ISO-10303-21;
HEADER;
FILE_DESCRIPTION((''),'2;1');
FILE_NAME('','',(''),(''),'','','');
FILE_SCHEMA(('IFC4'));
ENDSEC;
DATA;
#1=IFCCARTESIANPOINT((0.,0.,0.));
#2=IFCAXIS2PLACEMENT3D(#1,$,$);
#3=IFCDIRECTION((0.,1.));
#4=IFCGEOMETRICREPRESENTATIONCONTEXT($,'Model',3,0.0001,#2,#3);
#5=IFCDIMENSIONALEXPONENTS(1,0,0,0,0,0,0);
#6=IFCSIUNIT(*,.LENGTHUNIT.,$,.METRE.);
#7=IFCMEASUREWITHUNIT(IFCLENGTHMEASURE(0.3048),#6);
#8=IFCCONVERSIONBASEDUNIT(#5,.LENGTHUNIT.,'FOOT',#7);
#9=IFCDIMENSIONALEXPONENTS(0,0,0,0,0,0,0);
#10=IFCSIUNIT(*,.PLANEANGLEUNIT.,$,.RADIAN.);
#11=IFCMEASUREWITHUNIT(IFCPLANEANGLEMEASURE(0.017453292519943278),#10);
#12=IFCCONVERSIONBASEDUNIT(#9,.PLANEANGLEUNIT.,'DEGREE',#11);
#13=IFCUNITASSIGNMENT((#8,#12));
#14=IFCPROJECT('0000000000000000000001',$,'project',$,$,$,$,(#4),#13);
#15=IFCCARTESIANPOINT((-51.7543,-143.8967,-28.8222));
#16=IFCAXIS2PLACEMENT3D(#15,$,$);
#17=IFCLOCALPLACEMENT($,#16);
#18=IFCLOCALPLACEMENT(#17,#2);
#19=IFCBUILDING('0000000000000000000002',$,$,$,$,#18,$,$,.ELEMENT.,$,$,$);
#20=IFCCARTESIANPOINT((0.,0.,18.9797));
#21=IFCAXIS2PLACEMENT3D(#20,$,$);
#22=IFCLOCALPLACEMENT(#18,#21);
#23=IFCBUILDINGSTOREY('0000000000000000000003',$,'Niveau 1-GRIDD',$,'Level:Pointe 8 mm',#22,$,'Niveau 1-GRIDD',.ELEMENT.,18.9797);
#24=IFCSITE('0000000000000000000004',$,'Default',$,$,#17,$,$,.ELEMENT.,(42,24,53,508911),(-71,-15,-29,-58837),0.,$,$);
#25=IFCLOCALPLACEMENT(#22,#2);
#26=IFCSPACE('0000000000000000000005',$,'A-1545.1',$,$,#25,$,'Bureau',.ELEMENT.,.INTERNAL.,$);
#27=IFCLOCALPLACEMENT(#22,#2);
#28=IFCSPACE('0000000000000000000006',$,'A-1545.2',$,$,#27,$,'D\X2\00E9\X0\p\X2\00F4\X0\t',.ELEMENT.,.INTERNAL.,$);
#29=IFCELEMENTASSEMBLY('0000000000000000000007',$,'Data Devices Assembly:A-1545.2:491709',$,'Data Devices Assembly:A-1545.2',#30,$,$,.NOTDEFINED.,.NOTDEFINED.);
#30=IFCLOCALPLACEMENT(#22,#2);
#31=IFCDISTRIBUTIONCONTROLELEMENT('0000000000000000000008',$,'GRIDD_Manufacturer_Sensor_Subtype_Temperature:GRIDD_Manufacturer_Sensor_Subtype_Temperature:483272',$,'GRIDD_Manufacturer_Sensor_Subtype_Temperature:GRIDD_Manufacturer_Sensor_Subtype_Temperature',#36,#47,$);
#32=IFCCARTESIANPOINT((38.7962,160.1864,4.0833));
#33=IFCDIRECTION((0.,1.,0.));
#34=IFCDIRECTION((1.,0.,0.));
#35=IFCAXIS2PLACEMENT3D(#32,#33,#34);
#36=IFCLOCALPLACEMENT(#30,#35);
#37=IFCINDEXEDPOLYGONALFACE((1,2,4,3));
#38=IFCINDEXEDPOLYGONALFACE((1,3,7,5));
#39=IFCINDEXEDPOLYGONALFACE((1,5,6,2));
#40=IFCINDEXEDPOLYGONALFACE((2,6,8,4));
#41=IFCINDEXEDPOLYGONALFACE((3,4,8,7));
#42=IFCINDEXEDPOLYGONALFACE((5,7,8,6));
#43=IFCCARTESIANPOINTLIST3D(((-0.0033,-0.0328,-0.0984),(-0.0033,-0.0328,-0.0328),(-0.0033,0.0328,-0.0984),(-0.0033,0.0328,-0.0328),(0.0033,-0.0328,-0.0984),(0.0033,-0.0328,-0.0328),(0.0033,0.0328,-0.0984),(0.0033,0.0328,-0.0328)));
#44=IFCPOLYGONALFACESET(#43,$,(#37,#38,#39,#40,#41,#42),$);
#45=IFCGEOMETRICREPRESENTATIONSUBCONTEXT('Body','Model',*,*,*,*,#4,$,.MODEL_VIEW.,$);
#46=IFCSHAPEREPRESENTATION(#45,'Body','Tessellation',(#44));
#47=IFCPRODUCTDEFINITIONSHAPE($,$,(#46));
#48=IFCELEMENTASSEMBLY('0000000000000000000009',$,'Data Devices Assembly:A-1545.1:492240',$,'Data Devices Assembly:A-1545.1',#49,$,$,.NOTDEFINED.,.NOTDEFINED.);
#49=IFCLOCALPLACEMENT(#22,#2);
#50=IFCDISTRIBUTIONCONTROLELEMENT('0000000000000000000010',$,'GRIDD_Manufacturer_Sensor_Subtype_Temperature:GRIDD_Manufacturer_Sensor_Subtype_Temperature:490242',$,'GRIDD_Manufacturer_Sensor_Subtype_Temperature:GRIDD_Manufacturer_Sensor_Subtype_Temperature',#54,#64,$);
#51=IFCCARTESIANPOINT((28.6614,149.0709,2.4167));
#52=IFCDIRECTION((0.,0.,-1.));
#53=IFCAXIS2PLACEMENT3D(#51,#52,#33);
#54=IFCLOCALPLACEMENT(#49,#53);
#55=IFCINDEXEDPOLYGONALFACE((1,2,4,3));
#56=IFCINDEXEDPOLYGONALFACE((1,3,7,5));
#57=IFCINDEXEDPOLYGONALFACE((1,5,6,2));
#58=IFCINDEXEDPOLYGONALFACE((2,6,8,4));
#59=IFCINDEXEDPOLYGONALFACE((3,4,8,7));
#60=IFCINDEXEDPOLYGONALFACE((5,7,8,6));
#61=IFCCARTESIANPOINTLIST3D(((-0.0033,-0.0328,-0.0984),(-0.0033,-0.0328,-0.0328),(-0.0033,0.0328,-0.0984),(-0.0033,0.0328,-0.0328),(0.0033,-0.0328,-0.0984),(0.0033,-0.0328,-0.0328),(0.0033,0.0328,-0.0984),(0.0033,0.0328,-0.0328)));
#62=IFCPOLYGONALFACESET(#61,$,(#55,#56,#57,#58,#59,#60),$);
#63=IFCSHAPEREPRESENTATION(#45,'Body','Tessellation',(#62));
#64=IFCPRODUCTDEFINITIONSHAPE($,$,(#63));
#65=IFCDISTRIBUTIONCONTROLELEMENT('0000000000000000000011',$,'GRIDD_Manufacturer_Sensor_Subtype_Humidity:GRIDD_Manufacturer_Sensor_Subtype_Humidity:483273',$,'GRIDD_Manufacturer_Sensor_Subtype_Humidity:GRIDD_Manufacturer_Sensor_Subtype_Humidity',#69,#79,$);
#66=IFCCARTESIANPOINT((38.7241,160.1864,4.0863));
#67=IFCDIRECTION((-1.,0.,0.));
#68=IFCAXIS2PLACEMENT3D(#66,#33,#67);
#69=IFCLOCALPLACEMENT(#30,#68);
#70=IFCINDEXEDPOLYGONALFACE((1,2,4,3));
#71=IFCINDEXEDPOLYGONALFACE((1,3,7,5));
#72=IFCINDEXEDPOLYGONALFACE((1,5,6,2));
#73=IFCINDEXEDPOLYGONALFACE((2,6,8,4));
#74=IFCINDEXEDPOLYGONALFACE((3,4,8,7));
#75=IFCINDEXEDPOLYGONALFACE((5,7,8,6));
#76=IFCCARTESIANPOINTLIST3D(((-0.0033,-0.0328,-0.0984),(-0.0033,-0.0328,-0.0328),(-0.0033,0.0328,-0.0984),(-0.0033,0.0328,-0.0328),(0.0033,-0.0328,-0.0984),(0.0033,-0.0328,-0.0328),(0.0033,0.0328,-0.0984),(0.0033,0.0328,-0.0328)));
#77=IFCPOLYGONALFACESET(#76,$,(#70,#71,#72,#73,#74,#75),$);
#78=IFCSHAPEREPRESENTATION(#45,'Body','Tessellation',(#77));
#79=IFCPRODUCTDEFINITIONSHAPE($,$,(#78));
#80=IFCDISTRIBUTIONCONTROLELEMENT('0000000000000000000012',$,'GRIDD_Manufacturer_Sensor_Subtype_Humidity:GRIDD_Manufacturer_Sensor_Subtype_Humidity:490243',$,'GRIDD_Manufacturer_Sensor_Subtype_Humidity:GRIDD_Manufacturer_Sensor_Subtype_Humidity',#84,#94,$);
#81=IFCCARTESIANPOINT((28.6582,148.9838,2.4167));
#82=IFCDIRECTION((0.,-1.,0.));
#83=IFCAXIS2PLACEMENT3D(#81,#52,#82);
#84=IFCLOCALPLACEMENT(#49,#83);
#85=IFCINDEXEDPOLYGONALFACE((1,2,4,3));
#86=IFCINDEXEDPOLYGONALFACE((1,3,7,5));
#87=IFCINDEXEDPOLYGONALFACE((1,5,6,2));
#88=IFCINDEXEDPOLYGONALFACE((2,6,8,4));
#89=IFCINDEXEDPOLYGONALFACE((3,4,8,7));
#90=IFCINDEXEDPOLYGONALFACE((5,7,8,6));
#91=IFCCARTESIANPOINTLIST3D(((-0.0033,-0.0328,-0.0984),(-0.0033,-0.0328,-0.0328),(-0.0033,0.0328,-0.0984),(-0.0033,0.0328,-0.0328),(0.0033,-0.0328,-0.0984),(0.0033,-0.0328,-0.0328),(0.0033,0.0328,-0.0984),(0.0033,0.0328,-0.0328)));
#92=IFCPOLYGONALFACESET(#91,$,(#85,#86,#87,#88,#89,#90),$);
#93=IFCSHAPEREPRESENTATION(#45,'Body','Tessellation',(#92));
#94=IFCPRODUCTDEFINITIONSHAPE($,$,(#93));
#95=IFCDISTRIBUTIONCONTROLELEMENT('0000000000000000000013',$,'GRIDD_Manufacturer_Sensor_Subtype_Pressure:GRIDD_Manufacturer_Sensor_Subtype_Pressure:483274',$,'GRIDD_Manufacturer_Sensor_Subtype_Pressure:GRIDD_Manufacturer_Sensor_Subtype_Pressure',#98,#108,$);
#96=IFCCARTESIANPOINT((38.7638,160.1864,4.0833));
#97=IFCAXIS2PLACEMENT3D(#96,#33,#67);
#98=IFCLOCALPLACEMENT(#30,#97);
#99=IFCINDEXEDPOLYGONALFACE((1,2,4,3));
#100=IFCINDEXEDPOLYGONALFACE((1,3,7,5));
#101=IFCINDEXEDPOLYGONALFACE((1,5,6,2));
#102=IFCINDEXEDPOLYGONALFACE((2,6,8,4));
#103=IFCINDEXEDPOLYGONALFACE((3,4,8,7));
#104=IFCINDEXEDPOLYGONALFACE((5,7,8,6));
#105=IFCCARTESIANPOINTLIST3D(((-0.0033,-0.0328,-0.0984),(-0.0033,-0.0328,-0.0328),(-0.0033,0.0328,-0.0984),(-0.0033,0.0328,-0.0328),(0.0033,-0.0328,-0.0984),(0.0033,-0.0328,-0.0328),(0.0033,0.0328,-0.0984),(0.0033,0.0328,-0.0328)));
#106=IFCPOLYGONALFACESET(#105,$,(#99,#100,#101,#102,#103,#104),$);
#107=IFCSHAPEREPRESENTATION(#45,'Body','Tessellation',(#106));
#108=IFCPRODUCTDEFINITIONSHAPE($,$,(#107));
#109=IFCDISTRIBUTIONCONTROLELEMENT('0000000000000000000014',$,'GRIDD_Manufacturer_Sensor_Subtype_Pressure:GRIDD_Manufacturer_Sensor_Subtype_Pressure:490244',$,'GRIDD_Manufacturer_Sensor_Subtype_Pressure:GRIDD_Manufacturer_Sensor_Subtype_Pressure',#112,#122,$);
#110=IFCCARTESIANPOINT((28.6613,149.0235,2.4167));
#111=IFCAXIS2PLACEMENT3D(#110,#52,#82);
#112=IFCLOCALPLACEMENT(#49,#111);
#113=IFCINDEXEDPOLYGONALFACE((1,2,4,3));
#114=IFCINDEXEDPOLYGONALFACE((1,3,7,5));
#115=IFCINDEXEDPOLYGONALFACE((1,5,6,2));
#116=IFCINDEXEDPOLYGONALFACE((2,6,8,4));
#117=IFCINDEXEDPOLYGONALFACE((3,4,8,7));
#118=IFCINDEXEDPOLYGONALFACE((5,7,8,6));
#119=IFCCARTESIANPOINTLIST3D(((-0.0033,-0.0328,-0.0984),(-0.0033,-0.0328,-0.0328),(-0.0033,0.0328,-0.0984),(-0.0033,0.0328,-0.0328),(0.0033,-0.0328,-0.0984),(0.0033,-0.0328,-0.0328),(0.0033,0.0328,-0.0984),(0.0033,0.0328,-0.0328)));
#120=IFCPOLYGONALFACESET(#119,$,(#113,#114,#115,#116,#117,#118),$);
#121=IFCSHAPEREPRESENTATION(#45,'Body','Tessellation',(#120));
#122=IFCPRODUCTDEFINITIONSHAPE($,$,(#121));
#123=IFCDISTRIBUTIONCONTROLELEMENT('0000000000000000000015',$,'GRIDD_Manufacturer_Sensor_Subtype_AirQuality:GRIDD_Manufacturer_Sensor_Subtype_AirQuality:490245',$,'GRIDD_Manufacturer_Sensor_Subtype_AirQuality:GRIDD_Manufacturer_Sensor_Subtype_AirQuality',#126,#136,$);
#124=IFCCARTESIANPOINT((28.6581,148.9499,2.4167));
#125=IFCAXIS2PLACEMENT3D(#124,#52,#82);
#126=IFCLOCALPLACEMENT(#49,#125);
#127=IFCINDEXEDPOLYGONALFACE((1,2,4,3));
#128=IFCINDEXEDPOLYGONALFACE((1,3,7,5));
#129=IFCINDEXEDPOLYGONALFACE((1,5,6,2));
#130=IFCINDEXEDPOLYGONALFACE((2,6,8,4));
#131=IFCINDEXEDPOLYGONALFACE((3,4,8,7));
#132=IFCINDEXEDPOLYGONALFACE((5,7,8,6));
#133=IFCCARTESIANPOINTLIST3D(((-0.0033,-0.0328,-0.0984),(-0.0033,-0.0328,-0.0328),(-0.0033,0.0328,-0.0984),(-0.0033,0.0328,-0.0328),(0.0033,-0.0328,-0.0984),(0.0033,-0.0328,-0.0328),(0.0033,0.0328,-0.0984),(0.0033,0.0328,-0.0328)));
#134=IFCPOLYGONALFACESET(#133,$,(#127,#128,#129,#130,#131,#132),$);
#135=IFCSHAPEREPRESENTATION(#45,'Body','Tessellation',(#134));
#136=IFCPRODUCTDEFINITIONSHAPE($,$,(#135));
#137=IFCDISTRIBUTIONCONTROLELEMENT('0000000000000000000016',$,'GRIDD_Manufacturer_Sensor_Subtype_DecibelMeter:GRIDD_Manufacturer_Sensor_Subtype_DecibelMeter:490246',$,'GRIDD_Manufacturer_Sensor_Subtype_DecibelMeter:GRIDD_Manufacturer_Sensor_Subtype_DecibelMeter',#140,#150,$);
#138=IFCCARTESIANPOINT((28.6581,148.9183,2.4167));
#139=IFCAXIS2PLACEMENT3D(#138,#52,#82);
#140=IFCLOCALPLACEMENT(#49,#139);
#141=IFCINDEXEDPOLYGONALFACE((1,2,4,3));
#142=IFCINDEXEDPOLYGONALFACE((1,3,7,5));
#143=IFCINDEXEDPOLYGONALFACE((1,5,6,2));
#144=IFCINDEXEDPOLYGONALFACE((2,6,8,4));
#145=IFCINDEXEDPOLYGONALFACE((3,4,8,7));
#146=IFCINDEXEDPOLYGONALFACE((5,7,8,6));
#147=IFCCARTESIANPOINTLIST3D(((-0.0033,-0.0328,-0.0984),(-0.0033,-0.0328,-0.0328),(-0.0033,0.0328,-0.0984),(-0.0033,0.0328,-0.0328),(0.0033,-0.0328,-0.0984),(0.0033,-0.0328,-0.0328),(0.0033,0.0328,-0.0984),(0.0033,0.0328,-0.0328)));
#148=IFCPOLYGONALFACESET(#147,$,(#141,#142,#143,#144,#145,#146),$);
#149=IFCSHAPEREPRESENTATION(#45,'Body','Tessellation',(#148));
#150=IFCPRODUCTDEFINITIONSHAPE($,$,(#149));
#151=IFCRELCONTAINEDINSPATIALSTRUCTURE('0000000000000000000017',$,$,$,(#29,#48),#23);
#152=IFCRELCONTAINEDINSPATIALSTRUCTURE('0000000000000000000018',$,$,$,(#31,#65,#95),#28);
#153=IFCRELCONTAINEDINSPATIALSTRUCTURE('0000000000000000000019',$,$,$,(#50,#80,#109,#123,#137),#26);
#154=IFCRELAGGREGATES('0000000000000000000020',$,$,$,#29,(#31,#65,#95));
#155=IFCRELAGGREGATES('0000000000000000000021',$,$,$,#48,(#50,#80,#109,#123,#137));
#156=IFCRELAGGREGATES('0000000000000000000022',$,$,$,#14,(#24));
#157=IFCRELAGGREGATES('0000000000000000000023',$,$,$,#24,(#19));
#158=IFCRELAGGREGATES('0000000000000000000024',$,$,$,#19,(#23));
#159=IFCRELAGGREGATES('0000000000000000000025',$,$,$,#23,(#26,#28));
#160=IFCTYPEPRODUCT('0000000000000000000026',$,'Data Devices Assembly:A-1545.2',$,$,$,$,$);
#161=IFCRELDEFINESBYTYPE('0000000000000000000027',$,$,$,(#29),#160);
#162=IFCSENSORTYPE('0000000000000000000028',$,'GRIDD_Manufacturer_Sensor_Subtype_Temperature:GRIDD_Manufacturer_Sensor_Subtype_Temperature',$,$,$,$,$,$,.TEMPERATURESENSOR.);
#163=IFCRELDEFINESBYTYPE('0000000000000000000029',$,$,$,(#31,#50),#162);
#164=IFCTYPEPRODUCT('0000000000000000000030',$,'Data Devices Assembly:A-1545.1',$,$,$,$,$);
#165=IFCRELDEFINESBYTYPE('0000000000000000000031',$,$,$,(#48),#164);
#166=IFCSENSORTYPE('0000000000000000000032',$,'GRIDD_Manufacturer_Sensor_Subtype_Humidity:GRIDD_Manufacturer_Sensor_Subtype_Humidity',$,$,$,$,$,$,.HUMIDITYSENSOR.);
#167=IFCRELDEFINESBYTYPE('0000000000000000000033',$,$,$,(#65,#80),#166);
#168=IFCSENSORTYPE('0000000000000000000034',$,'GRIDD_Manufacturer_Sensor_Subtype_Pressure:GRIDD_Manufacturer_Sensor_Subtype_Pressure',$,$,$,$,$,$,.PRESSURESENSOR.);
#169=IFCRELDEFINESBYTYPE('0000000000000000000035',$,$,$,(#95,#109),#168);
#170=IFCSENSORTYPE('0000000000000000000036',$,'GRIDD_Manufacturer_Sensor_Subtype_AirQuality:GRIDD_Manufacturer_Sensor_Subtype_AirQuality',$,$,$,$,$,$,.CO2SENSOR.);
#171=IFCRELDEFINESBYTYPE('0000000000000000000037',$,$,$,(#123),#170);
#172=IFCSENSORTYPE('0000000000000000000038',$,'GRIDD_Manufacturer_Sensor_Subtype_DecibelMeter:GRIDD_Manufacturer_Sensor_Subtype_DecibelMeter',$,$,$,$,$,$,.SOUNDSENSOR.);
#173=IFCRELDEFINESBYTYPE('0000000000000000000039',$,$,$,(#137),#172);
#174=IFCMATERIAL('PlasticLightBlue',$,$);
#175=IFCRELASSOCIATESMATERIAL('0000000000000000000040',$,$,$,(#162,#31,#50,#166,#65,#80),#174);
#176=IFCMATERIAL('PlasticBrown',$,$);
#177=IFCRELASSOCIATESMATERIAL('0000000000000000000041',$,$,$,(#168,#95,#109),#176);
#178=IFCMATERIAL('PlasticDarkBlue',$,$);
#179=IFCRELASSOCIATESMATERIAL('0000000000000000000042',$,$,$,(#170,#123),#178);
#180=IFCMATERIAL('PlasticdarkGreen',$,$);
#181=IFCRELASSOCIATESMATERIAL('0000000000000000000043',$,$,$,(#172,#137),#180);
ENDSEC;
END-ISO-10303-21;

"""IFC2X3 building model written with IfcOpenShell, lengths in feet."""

from ifc_helpers import new_model, entity, si_unit, converted_unit, direction, frame, origin, origin_2d_with_axis, place, context, subcontext, project, spatial, rectangle, extrude, source, transform, mapped, material, type_object, type_shapes, element, aggregate, save


model = new_model("IFC2X3")

# Units and contexts
model_context = context("Model", 3, precision=0.0001, world=origin(), true_north=direction((0.0, 1.0)))
body_context = subcontext(model_context, "Body", "Model", "MODEL_VIEW")
ifc_project = project(units=[converted_unit("LENGTHUNIT", "FOOT", entity("IfcLengthMeasure", 0.3048), si_unit("LENGTHUNIT", "METRE"), dimensions=[1, 0, 0, 0, 0, 0, 0]), converted_unit("PLANEANGLEUNIT", "DEGREE", entity("IfcPlaneAngleMeasure", 0.017453292519943278), si_unit("PLANEANGLEUNIT", "RADIAN"), dimensions=[0, 0, 0, 0, 0, 0, 0])], contexts=[model_context])

# Site, building, storey
site_placement = place(None, frame((-51.7543, -143.8967, -28.8222)))
site = spatial("IfcSite", under=ifc_project, at=site_placement, Name="Default", CompositionType="ELEMENT", RefLatitude=(42, 24, 53, 508911), RefLongitude=(-71, -15, -29, -58837), RefElevation=0.0)
building_placement = place(site_placement, origin())
building = spatial("IfcBuilding", under=site, at=building_placement, CompositionType="ELEMENT")
storey_placement = place(building_placement, frame((0.0, 0.0, 18.9797)))
storey = spatial("IfcBuildingStorey", under=building, at=storey_placement, Name="Niveau 1-GRIDD", ObjectType="Level:Pointe 8 mm", LongName="Niveau 1-GRIDD", CompositionType="ELEMENT", Elevation=18.9797)

# Shared definitions
space_1_placement = place(storey_placement, origin())
space_1 = spatial("IfcSpace", under=storey, at=space_1_placement, Name="A-1545.1", LongName="Bureau", CompositionType="ELEMENT", InteriorOrExteriorSpace="INTERNAL")

# Shared definitions
space_2_placement = place(storey_placement, origin())
space_2 = spatial("IfcSpace", under=storey, at=space_2_placement, Name="A-1545.2", LongName="Dépôt", CompositionType="ELEMENT", InteriorOrExteriorSpace="INTERNAL")

# Element assemblies, distribution control elements
type_product_1 = type_object("IfcTypeProduct", Name="Data Devices Assembly:A-1545.2")
assembly_1_placement = place(storey_placement, origin())
assembly_1 = element("IfcElementAssembly", 1, at=assembly_1_placement, inside=storey, type_object=type_product_1, Name="Data Devices Assembly:A-1545.2:491709", ObjectType="Data Devices Assembly:A-1545.2", AssemblyPlace="NOTDEFINED", PredefinedType="NOTDEFINED")
ifc_material_1 = material(Name="PlasticLightBlue")
sensor_type_1 = type_object("IfcSensorType", Name="GRIDD_Manufacturer_Sensor_Subtype_Temperature:GRIDD_Manufacturer_Sensor_Subtype_Temperature", PredefinedType="TEMPERATURESENSOR", material=ifc_material_1)
shared_shape_1 = source(origin(), body_context, "Body", "SweptSolid", [
    extrude(rectangle(XDim=0.0066, YDim=0.0656, at=origin_2d_with_axis()), frame((0.0, 0.0, -0.0984), z_axis=(0.0, 0.0, 1.0), x_axis=(-1.0, 0.0, 0.0)), (0.0, 0.0, 1.0), 0.0656),
])
type_shapes(sensor_type_1, [shared_shape_1])
distribution_control_element_1_placement = place(assembly_1_placement, frame((38.7962, 160.1864, 4.0833), z_axis=(0.0, 1.0, 0.0), x_axis=(1.0, 0.0, 0.0)))
distribution_control_element_1 = element("IfcDistributionControlElement", 2, at=distribution_control_element_1_placement, inside=space_2, type_object=sensor_type_1, material=ifc_material_1, Name="GRIDD_Manufacturer_Sensor_Subtype_Temperature:GRIDD_Manufacturer_Sensor_Subtype_Temperature:483272", ObjectType="GRIDD_Manufacturer_Sensor_Subtype_Temperature:GRIDD_Manufacturer_Sensor_Subtype_Temperature", context=body_context, shape_type="MappedRepresentation", body=[
    mapped(shared_shape_1, transform((0.0, 0.0, 0.0), scale=1.0)),
])
type_product_2 = type_object("IfcTypeProduct", Name="Data Devices Assembly:A-1545.1")
assembly_2_placement = place(storey_placement, origin())
assembly_2 = element("IfcElementAssembly", 3, at=assembly_2_placement, inside=storey, type_object=type_product_2, Name="Data Devices Assembly:A-1545.1:492240", ObjectType="Data Devices Assembly:A-1545.1", AssemblyPlace="NOTDEFINED", PredefinedType="NOTDEFINED")
distribution_control_element_2_placement = place(assembly_2_placement, frame((28.6614, 149.0709, 2.4167), z_axis=(0.0, 0.0, -1.0), x_axis=(0.0, 1.0, 0.0)))
distribution_control_element_2 = element("IfcDistributionControlElement", 4, at=distribution_control_element_2_placement, inside=space_1, type_object=sensor_type_1, material=ifc_material_1, Name="GRIDD_Manufacturer_Sensor_Subtype_Temperature:GRIDD_Manufacturer_Sensor_Subtype_Temperature:490242", ObjectType="GRIDD_Manufacturer_Sensor_Subtype_Temperature:GRIDD_Manufacturer_Sensor_Subtype_Temperature", context=body_context, shape_type="MappedRepresentation", body=[
    mapped(shared_shape_1, transform((0.0, 0.0, 0.0), scale=1.0)),
])

# Distribution control elements
sensor_type_2 = type_object("IfcSensorType", Name="GRIDD_Manufacturer_Sensor_Subtype_Humidity:GRIDD_Manufacturer_Sensor_Subtype_Humidity", PredefinedType="HUMIDITYSENSOR", material=ifc_material_1)
shared_shape_2 = source(origin(), body_context, "Body", "SweptSolid", [
    extrude(rectangle(XDim=0.0066, YDim=0.0656, at=origin_2d_with_axis()), frame((0.0, 0.0, -0.0984), z_axis=(0.0, 0.0, 1.0), x_axis=(-1.0, 0.0, 0.0)), (0.0, 0.0, 1.0), 0.0656),
])
type_shapes(sensor_type_2, [shared_shape_2])
distribution_control_element_3_placement = place(assembly_1_placement, frame((38.7241, 160.1864, 4.0863), z_axis=(0.0, 1.0, 0.0), x_axis=(-1.0, 0.0, 0.0)))
distribution_control_element_3 = element("IfcDistributionControlElement", 5, at=distribution_control_element_3_placement, inside=space_2, type_object=sensor_type_2, material=ifc_material_1, Name="GRIDD_Manufacturer_Sensor_Subtype_Humidity:GRIDD_Manufacturer_Sensor_Subtype_Humidity:483273", ObjectType="GRIDD_Manufacturer_Sensor_Subtype_Humidity:GRIDD_Manufacturer_Sensor_Subtype_Humidity", context=body_context, shape_type="MappedRepresentation", body=[
    mapped(shared_shape_2, transform((0.0, 0.0, 0.0), scale=1.0)),
])
distribution_control_element_4_placement = place(assembly_2_placement, frame((28.6582, 148.9838, 2.4167), z_axis=(0.0, 0.0, -1.0), x_axis=(0.0, -1.0, 0.0)))
distribution_control_element_4 = element("IfcDistributionControlElement", 6, at=distribution_control_element_4_placement, inside=space_1, type_object=sensor_type_2, material=ifc_material_1, Name="GRIDD_Manufacturer_Sensor_Subtype_Humidity:GRIDD_Manufacturer_Sensor_Subtype_Humidity:490243", ObjectType="GRIDD_Manufacturer_Sensor_Subtype_Humidity:GRIDD_Manufacturer_Sensor_Subtype_Humidity", context=body_context, shape_type="MappedRepresentation", body=[
    mapped(shared_shape_2, transform((0.0, 0.0, 0.0), scale=1.0)),
])
ifc_material_2 = material(Name="PlasticBrown")
sensor_type_3 = type_object("IfcSensorType", Name="GRIDD_Manufacturer_Sensor_Subtype_Pressure:GRIDD_Manufacturer_Sensor_Subtype_Pressure", PredefinedType="PRESSURESENSOR", material=ifc_material_2)
shared_shape_3 = source(origin(), body_context, "Body", "SweptSolid", [
    extrude(rectangle(XDim=0.0066, YDim=0.0656, at=origin_2d_with_axis()), frame((0.0, 0.0, -0.0984), z_axis=(0.0, 0.0, 1.0), x_axis=(-1.0, 0.0, 0.0)), (0.0, 0.0, 1.0), 0.0656),
])
type_shapes(sensor_type_3, [shared_shape_3])
distribution_control_element_5_placement = place(assembly_1_placement, frame((38.7638, 160.1864, 4.0833), z_axis=(0.0, 1.0, 0.0), x_axis=(-1.0, 0.0, 0.0)))
distribution_control_element_5 = element("IfcDistributionControlElement", 7, at=distribution_control_element_5_placement, inside=space_2, type_object=sensor_type_3, material=ifc_material_2, Name="GRIDD_Manufacturer_Sensor_Subtype_Pressure:GRIDD_Manufacturer_Sensor_Subtype_Pressure:483274", ObjectType="GRIDD_Manufacturer_Sensor_Subtype_Pressure:GRIDD_Manufacturer_Sensor_Subtype_Pressure", context=body_context, shape_type="MappedRepresentation", body=[
    mapped(shared_shape_3, transform((0.0, 0.0, 0.0), scale=1.0)),
])
aggregate(assembly_1, [distribution_control_element_1, distribution_control_element_3, distribution_control_element_5])
distribution_control_element_6_placement = place(assembly_2_placement, frame((28.6613, 149.0235, 2.4167), z_axis=(0.0, 0.0, -1.0), x_axis=(0.0, -1.0, 0.0)))
distribution_control_element_6 = element("IfcDistributionControlElement", 8, at=distribution_control_element_6_placement, inside=space_1, type_object=sensor_type_3, material=ifc_material_2, Name="GRIDD_Manufacturer_Sensor_Subtype_Pressure:GRIDD_Manufacturer_Sensor_Subtype_Pressure:490244", ObjectType="GRIDD_Manufacturer_Sensor_Subtype_Pressure:GRIDD_Manufacturer_Sensor_Subtype_Pressure", context=body_context, shape_type="MappedRepresentation", body=[
    mapped(shared_shape_3, transform((0.0, 0.0, 0.0), scale=1.0)),
])
ifc_material_3 = material(Name="PlasticDarkBlue")
sensor_type_4 = type_object("IfcSensorType", Name="GRIDD_Manufacturer_Sensor_Subtype_AirQuality:GRIDD_Manufacturer_Sensor_Subtype_AirQuality", PredefinedType="CO2SENSOR", material=ifc_material_3)
shared_shape_4 = source(origin(), body_context, "Body", "SweptSolid", [
    extrude(rectangle(XDim=0.0066, YDim=0.0656, at=origin_2d_with_axis()), frame((0.0, 0.0, -0.0984), z_axis=(0.0, 0.0, 1.0), x_axis=(-1.0, 0.0, 0.0)), (0.0, 0.0, 1.0), 0.0656),
])
type_shapes(sensor_type_4, [shared_shape_4])
distribution_control_element_7_placement = place(assembly_2_placement, frame((28.6581, 148.9499, 2.4167), z_axis=(0.0, 0.0, -1.0), x_axis=(0.0, -1.0, 0.0)))
distribution_control_element_7 = element("IfcDistributionControlElement", 9, at=distribution_control_element_7_placement, inside=space_1, type_object=sensor_type_4, material=ifc_material_3, Name="GRIDD_Manufacturer_Sensor_Subtype_AirQuality:GRIDD_Manufacturer_Sensor_Subtype_AirQuality:490245", ObjectType="GRIDD_Manufacturer_Sensor_Subtype_AirQuality:GRIDD_Manufacturer_Sensor_Subtype_AirQuality", context=body_context, shape_type="MappedRepresentation", body=[
    mapped(shared_shape_4, transform((0.0, 0.0, 0.0), scale=1.0)),
])
ifc_material_4 = material(Name="PlasticdarkGreen")
sensor_type_5 = type_object("IfcSensorType", Name="GRIDD_Manufacturer_Sensor_Subtype_DecibelMeter:GRIDD_Manufacturer_Sensor_Subtype_DecibelMeter", PredefinedType="SOUNDSENSOR", material=ifc_material_4)
shared_shape_5 = source(origin(), body_context, "Body", "SweptSolid", [
    extrude(rectangle(XDim=0.0066, YDim=0.0656, at=origin_2d_with_axis()), frame((0.0, 0.0, -0.0984), z_axis=(0.0, 0.0, 1.0), x_axis=(-1.0, 0.0, 0.0)), (0.0, 0.0, 1.0), 0.0656),
])
type_shapes(sensor_type_5, [shared_shape_5])
distribution_control_element_8_placement = place(assembly_2_placement, frame((28.6581, 148.9183, 2.4167), z_axis=(0.0, 0.0, -1.0), x_axis=(0.0, -1.0, 0.0)))
distribution_control_element_8 = element("IfcDistributionControlElement", 10, at=distribution_control_element_8_placement, inside=space_1, type_object=sensor_type_5, material=ifc_material_4, Name="GRIDD_Manufacturer_Sensor_Subtype_DecibelMeter:GRIDD_Manufacturer_Sensor_Subtype_DecibelMeter:490246", ObjectType="GRIDD_Manufacturer_Sensor_Subtype_DecibelMeter:GRIDD_Manufacturer_Sensor_Subtype_DecibelMeter", context=body_context, shape_type="MappedRepresentation", body=[
    mapped(shared_shape_5, transform((0.0, 0.0, 0.0), scale=1.0)),
])
aggregate(assembly_2, [distribution_control_element_2, distribution_control_element_4, distribution_control_element_6, distribution_control_element_7, distribution_control_element_8])

save(model, "model.ifc")
